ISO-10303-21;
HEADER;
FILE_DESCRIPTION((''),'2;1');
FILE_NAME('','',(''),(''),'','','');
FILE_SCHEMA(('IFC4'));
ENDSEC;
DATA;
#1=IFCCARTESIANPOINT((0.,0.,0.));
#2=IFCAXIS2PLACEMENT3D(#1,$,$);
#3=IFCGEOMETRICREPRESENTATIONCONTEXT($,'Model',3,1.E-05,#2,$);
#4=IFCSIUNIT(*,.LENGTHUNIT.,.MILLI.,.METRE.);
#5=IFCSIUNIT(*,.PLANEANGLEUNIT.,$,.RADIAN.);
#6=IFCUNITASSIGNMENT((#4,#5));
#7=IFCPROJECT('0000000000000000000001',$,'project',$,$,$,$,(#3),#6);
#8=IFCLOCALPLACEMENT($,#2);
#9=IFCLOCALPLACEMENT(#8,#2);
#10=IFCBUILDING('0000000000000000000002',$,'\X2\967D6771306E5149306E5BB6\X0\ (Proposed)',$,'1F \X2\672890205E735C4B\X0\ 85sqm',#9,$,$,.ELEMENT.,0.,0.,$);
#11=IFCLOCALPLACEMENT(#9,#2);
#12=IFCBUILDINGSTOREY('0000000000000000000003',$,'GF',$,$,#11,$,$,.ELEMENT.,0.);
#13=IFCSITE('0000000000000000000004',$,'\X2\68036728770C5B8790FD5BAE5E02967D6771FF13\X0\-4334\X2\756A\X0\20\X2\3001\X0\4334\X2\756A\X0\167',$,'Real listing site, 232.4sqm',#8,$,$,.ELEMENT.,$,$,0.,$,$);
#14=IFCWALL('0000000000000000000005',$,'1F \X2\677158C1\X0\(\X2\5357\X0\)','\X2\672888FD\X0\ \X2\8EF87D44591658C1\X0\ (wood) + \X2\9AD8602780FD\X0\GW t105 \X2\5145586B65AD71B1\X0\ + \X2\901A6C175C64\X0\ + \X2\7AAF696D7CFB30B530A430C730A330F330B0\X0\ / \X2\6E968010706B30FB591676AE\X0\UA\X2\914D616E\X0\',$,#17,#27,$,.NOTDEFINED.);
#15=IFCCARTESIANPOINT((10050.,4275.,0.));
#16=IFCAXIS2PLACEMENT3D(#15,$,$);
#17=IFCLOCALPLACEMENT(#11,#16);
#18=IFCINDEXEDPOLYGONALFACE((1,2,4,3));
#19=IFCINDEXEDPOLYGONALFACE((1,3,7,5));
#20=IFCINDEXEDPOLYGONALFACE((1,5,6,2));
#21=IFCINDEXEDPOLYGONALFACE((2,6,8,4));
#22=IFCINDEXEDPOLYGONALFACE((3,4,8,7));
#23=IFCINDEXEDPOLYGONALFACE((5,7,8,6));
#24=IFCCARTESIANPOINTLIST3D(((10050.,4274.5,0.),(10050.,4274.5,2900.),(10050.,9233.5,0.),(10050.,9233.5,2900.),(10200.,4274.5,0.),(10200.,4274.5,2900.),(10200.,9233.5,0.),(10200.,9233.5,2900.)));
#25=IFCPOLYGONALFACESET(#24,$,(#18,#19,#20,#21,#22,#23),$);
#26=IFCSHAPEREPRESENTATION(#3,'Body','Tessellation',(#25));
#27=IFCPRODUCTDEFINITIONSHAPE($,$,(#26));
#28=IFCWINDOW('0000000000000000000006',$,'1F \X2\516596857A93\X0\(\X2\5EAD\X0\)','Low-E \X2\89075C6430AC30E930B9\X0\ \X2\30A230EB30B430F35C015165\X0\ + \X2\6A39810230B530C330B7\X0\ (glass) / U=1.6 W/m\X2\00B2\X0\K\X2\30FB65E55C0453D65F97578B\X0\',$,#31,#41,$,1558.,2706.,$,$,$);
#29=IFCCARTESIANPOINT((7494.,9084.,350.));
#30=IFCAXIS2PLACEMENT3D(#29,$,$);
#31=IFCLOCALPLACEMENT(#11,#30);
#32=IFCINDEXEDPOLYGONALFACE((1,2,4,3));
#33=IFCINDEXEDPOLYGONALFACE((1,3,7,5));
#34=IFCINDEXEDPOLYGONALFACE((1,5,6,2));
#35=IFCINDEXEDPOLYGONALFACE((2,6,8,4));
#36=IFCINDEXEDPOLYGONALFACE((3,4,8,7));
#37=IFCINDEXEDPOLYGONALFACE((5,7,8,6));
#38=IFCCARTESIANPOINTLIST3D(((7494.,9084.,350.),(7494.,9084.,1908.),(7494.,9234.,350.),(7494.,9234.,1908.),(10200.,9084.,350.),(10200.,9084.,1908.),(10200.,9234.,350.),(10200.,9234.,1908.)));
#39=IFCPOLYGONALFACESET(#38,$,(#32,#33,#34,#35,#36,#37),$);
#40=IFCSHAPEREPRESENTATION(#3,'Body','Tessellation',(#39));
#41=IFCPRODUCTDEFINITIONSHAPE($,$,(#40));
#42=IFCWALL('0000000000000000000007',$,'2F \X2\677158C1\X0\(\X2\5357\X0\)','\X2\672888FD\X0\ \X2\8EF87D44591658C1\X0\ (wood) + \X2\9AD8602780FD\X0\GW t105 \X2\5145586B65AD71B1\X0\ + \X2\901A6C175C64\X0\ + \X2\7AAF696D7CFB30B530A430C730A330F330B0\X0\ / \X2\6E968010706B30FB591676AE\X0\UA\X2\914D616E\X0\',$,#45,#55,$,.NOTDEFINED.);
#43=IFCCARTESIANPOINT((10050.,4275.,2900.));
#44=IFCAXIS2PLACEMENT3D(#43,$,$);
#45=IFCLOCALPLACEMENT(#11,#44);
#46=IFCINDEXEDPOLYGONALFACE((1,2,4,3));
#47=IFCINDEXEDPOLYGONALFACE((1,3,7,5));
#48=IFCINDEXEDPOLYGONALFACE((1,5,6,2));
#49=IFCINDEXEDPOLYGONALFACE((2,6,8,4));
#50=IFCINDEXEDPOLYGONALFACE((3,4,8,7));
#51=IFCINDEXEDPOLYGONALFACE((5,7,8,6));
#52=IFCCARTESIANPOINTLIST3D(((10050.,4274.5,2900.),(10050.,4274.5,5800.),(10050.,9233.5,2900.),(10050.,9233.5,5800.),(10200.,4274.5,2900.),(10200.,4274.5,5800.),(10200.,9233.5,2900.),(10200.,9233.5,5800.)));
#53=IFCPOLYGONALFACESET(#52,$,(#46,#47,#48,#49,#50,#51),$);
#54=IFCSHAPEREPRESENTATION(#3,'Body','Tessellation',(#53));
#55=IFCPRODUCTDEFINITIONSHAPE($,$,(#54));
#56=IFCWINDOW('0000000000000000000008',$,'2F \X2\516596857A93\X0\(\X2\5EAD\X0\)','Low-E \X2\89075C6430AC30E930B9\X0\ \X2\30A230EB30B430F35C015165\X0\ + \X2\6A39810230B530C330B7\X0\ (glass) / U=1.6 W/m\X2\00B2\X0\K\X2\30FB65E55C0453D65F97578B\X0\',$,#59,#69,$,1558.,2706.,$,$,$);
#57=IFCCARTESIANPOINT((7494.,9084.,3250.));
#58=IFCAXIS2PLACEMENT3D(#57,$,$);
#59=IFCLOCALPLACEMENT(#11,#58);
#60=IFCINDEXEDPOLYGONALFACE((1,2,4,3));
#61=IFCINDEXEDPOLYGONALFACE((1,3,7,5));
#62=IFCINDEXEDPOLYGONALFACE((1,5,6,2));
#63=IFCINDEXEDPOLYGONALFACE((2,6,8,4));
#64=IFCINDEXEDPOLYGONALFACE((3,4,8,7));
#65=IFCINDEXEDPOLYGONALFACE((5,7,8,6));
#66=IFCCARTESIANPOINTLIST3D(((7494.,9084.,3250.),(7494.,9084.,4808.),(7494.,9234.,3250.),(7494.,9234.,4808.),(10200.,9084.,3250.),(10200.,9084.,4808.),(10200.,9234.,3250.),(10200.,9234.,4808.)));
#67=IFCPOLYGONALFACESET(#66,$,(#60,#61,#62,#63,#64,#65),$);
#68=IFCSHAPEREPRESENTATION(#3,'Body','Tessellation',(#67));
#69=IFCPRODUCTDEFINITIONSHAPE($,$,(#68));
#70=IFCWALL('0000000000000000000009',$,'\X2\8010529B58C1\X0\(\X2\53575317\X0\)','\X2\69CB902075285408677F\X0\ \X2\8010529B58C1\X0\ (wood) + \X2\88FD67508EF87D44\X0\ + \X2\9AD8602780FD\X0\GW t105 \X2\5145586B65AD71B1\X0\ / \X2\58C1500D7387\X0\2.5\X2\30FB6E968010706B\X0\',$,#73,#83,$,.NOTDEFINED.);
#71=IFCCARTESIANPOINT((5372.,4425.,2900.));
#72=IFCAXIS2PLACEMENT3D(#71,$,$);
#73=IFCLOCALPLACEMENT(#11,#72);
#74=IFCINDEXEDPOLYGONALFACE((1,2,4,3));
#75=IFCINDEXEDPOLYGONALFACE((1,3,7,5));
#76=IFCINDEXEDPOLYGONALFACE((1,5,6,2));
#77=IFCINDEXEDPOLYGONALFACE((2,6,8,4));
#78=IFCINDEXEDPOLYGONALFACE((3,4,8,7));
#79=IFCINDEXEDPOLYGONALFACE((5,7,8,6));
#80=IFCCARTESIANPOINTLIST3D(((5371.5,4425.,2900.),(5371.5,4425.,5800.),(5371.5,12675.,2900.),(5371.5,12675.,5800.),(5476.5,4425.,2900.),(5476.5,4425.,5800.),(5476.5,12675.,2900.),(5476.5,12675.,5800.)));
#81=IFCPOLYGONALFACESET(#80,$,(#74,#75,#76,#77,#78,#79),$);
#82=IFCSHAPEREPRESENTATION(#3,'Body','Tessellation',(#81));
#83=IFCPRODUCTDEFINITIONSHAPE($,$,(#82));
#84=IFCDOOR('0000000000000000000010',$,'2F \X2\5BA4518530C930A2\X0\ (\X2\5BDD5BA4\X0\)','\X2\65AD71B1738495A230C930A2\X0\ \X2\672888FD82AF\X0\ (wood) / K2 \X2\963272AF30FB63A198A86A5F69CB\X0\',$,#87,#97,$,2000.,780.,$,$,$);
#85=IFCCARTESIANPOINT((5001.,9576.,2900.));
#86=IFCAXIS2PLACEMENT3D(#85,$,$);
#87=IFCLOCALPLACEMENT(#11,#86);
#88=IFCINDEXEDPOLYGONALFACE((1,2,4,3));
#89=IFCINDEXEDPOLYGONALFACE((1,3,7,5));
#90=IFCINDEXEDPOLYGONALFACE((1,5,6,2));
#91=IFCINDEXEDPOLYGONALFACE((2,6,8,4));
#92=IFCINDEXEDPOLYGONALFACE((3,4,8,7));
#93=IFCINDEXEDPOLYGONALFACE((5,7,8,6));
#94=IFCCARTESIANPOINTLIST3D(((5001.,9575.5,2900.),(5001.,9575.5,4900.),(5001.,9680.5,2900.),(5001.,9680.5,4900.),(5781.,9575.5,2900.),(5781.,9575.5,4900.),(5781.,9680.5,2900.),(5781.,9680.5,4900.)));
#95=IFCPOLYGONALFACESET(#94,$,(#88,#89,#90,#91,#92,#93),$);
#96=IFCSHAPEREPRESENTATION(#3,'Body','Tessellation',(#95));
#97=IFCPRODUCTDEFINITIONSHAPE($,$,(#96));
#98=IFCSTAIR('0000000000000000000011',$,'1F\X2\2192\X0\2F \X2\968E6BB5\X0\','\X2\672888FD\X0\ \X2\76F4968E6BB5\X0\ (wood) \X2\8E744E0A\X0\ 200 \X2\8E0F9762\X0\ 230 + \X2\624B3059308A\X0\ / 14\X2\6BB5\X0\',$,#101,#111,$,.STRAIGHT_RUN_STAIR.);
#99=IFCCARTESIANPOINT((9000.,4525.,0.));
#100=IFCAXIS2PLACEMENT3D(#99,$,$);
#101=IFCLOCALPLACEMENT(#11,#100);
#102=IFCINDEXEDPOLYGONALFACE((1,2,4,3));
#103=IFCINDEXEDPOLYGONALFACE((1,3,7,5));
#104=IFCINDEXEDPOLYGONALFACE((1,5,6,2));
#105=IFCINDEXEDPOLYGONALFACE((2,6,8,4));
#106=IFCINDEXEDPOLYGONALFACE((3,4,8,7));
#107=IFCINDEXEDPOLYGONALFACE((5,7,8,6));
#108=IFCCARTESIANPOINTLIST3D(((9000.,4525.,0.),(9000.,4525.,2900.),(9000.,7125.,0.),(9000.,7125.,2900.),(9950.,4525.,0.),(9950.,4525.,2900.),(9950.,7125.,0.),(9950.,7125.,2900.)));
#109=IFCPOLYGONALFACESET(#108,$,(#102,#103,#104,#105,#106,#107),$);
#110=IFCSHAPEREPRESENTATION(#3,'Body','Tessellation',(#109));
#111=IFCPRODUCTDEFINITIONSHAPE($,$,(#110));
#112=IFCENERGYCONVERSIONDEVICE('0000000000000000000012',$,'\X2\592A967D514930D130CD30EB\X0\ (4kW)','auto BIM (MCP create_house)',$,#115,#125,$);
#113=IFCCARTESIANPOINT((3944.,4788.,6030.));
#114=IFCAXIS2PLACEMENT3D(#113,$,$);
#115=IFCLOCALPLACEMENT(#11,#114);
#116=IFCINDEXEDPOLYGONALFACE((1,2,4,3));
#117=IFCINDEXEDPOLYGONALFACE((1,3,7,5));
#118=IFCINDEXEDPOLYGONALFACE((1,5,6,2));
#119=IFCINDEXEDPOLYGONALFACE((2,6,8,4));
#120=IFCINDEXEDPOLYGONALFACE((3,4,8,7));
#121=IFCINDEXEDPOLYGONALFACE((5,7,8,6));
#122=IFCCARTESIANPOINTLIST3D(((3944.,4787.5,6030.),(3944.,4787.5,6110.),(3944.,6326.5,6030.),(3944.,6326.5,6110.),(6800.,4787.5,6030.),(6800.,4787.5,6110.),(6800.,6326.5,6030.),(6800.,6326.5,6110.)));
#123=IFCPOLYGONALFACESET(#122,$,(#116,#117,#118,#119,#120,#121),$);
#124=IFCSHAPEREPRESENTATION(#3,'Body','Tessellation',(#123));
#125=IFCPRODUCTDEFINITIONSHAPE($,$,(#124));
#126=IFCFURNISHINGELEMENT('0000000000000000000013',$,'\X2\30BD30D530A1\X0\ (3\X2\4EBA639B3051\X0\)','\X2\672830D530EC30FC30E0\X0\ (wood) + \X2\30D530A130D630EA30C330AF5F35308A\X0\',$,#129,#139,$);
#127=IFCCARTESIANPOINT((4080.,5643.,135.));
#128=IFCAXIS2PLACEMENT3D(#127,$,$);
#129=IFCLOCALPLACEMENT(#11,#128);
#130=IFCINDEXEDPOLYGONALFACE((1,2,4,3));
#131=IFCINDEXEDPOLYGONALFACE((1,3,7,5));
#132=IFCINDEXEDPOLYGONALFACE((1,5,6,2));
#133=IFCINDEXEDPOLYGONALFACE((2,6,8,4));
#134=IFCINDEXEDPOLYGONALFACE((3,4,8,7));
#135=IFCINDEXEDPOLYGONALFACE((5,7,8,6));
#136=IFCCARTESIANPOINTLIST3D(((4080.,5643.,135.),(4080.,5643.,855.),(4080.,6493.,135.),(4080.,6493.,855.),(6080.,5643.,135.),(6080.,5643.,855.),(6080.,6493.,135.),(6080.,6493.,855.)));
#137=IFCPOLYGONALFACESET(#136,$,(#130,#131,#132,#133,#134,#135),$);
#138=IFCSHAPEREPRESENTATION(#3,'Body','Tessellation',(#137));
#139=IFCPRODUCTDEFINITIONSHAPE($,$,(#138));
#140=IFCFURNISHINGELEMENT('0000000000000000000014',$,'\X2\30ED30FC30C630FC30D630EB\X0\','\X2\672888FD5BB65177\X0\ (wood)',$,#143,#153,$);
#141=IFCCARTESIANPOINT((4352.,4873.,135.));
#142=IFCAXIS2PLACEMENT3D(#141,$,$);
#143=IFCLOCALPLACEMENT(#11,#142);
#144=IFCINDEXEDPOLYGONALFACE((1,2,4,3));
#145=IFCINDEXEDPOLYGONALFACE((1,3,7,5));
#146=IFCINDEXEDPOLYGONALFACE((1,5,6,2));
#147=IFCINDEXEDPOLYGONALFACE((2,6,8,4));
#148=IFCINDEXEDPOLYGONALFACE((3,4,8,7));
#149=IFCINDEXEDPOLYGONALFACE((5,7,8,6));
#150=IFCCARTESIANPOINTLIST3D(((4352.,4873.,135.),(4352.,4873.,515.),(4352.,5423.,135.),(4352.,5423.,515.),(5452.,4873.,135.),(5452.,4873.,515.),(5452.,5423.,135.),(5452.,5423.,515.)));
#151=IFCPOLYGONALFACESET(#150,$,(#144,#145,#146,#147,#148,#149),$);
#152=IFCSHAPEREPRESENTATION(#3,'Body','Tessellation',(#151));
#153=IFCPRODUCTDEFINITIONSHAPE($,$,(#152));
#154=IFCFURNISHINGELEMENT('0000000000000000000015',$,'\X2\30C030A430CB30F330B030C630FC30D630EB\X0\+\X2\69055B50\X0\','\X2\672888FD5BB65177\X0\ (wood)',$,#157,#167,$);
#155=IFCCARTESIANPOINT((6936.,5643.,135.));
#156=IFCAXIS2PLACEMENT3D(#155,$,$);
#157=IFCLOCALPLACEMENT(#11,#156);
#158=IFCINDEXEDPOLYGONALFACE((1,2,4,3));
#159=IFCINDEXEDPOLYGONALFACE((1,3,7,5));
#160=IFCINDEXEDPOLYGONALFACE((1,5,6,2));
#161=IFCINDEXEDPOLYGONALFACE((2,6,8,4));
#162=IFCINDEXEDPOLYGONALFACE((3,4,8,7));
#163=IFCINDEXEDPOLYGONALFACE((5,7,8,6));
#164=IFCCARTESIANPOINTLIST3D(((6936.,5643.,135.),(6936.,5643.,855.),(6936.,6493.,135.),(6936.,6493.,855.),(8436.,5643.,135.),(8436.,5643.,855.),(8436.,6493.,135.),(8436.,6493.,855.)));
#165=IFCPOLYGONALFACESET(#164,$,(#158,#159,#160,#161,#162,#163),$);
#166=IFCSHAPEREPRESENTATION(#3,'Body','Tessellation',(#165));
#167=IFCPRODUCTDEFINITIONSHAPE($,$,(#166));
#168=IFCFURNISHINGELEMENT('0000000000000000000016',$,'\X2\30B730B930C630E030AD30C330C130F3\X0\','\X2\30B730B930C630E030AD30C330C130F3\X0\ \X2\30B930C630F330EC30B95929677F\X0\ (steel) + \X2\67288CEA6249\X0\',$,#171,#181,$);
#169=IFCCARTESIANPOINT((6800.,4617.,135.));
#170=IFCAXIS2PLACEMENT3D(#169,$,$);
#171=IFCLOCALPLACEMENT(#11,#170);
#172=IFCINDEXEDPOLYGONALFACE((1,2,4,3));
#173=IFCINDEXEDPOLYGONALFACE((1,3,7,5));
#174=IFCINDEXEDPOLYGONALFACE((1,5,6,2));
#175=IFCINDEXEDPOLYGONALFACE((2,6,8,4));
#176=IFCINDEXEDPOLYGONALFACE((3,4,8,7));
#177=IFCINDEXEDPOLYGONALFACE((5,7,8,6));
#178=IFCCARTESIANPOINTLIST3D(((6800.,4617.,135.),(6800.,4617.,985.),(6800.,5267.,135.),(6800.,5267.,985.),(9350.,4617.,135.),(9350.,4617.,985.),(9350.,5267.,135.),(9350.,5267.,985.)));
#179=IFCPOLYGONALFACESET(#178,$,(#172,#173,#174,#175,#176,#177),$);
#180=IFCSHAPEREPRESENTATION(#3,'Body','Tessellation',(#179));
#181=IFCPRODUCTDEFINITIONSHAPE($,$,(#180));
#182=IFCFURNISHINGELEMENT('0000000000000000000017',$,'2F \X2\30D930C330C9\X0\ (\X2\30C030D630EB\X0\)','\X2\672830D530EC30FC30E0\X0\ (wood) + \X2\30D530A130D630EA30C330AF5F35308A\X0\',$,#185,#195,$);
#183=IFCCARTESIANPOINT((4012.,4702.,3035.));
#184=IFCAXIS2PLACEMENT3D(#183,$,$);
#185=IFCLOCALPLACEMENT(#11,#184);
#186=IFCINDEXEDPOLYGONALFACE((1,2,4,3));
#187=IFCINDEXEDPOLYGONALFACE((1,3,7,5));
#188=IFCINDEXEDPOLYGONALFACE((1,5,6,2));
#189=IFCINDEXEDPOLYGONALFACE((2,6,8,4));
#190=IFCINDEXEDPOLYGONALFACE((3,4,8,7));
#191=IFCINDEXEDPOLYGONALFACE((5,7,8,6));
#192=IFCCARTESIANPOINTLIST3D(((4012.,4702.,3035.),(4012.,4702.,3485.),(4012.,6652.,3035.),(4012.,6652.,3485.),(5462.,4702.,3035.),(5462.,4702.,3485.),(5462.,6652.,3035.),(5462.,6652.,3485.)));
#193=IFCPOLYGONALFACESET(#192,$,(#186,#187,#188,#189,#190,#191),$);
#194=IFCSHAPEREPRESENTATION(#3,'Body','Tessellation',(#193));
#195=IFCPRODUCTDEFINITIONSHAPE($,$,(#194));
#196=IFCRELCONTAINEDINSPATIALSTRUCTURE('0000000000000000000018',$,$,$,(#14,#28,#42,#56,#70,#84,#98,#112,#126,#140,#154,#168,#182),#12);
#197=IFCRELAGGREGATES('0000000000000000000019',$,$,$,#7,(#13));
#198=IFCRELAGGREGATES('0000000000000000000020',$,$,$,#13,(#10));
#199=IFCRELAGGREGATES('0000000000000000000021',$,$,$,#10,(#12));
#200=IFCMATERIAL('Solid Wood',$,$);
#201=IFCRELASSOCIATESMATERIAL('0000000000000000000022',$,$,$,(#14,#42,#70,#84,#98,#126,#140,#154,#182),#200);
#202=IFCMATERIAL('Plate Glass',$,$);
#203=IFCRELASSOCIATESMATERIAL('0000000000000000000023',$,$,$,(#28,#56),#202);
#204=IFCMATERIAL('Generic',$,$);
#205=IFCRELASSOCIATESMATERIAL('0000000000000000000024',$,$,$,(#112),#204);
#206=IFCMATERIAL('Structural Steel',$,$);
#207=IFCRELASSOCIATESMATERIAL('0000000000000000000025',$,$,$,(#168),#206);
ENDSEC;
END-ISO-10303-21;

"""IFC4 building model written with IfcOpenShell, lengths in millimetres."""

from ifc_helpers import new_model, si_unit, frame, frame_2d, origin, place, context, project, spatial, rectangle, extrude, material, element, fill, save


model = new_model("IFC4")

# Units and contexts
model_context = context("Model", 3, precision=1e-05, world=origin())
ifc_project = project(units=[si_unit("LENGTHUNIT", "METRE", prefix="MILLI"), si_unit("PLANEANGLEUNIT", "RADIAN")], contexts=[model_context])

# Site, building, storey
site_placement = place(None, origin())
site = spatial("IfcSite", under=ifc_project, at=site_placement, Name="栃木県宇都宮市陽東３-4334番20、4334番167", ObjectType="Real listing site, 232.4sqm", CompositionType="ELEMENT", RefElevation=0.0)
building_placement = place(site_placement, origin())
building = spatial("IfcBuilding", under=site, at=building_placement, Name="陽東の光の家 (Proposed)", ObjectType="1F 木造平屋 85sqm", CompositionType="ELEMENT", ElevationOfRefHeight=0.0, ElevationOfTerrain=0.0)
storey_placement = place(building_placement, origin())
storey = spatial("IfcBuildingStorey", under=building, at=storey_placement, Name="GF", CompositionType="ELEMENT", Elevation=0.0)

# Wall, opening, window
ifc_material_1 = material(Name="Solid Wood")
wall_1_placement = place(storey_placement, frame((10050.0, 4275.0, 0.0)))
wall_1 = element("IfcWall", 1, at=wall_1_placement, inside=storey, material=ifc_material_1, Name="1F 東壁(南)", Description="木製 軸組外壁 (wood) + 高性能GW t105 充填断熱 + 通気層 + 窯業系サイディング / 準耐火・外皮UA配慮", PredefinedType="NOTDEFINED", context=model_context, shape_type="SweptSolid", body=[
    extrude(rectangle(XDim=150.0, YDim=4959.0, at=frame_2d((75.0, 2479.0))), frame((10050.0, 4275.0, 0.0)), (0.0, 0.0, 1.0), 2900.0),
])
opening_1_placement = place(storey_placement, frame((7494.0, 9084.0, 350.0)))
opening_1 = element("IfcOpeningElement", 2, at=opening_1_placement, cuts=wall_1, PredefinedType="NOTDEFINED", context=model_context, shape_type="SweptSolid", body=[
    extrude(rectangle(XDim=2706.0, YDim=150.0, at=frame_2d((1353.0, 75.0))), frame((7494.0, 9084.0, 350.0)), (0.0, 0.0, 1.0), 1558.0),
])
ifc_material_2 = material(Name="Plate Glass")
window_1_placement = place(storey_placement, frame((7494.0, 9084.0, 350.0)))
window_1 = element("IfcWindow", 3, at=window_1_placement, inside=storey, material=ifc_material_2, Name="1F 入隅窓(庭)", Description="Low-E 複層ガラス アルゴン封入 + 樹脂サッシ (glass) / U=1.6 W/m²K・日射取得型", OverallHeight=1558.0, OverallWidth=2706.0, context=model_context, shape_type="SweptSolid", body=[
    extrude(rectangle(XDim=2706.0, YDim=150.0, at=frame_2d((1353.0, 75.0))), frame((7494.0, 9084.0, 350.0)), (0.0, 0.0, 1.0), 1558.0),
])
fill(opening_1, window_1)

# Wall, opening, window
wall_2_placement = place(storey_placement, frame((10050.0, 4275.0, 2900.0)))
wall_2 = element("IfcWall", 4, at=wall_2_placement, inside=storey, material=ifc_material_1, Name="2F 東壁(南)", Description="木製 軸組外壁 (wood) + 高性能GW t105 充填断熱 + 通気層 + 窯業系サイディング / 準耐火・外皮UA配慮", PredefinedType="NOTDEFINED", context=model_context, shape_type="SweptSolid", body=[
    extrude(rectangle(XDim=150.0, YDim=4959.0, at=frame_2d((75.0, 2479.0))), frame((10050.0, 4275.0, 2900.0)), (0.0, 0.0, 1.0), 2900.0),
])
opening_2_placement = place(storey_placement, frame((7494.0, 9084.0, 3250.0)))
opening_2 = element("IfcOpeningElement", 5, at=opening_2_placement, cuts=wall_2, PredefinedType="NOTDEFINED", context=model_context, shape_type="SweptSolid", body=[
    extrude(rectangle(XDim=2706.0, YDim=150.0, at=frame_2d((1353.0, 75.0))), frame((7494.0, 9084.0, 3250.0)), (0.0, 0.0, 1.0), 1558.0),
])
window_2_placement = place(storey_placement, frame((7494.0, 9084.0, 3250.0)))
window_2 = element("IfcWindow", 6, at=window_2_placement, inside=storey, material=ifc_material_2, Name="2F 入隅窓(庭)", Description="Low-E 複層ガラス アルゴン封入 + 樹脂サッシ (glass) / U=1.6 W/m²K・日射取得型", OverallHeight=1558.0, OverallWidth=2706.0, context=model_context, shape_type="SweptSolid", body=[
    extrude(rectangle(XDim=2706.0, YDim=150.0, at=frame_2d((1353.0, 75.0))), frame((7494.0, 9084.0, 3250.0)), (0.0, 0.0, 1.0), 1558.0),
])
fill(opening_2, window_2)

# Wall, opening, door
wall_3_placement = place(storey_placement, frame((5372.0, 4425.0, 2900.0)))
wall_3 = element("IfcWall", 7, at=wall_3_placement, inside=storey, material=ifc_material_1, Name="耐力壁(南北)", Description="構造用合板 耐力壁 (wood) + 製材軸組 + 高性能GW t105 充填断熱 / 壁倍率2.5・準耐火", PredefinedType="NOTDEFINED", context=model_context, shape_type="SweptSolid", body=[
    extrude(rectangle(XDim=105.0, YDim=8250.0, at=frame_2d((52.0, 4125.0))), frame((5372.0, 4425.0, 2900.0)), (0.0, 0.0, 1.0), 2900.0),
])
opening_3_placement = place(storey_placement, frame((5001.0, 9576.0, 2900.0)))
opening_3 = element("IfcOpeningElement", 8, at=opening_3_placement, cuts=wall_3, PredefinedType="NOTDEFINED", context=model_context, shape_type="SweptSolid", body=[
    extrude(rectangle(XDim=780.0, YDim=105.0, at=frame_2d((390.0, 52.0))), frame((5001.0, 9576.0, 2900.0)), (0.0, 0.0, 1.0), 2000.0),
])
door_1_placement = place(storey_placement, frame((5001.0, 9576.0, 2900.0)))
door_1 = element("IfcDoor", 9, at=door_1_placement, inside=storey, material=ifc_material_1, Name="2F 室内ドア (寝室)", Description="断熱玄関ドア 木製芯 (wood) / K2 防犯・採風機構", OverallHeight=2000.0, OverallWidth=780.0, context=model_context, shape_type="SweptSolid", body=[
    extrude(rectangle(XDim=780.0, YDim=105.0, at=frame_2d((390.0, 52.0))), frame((5001.0, 9576.0, 2900.0)), (0.0, 0.0, 1.0), 2000.0),
])
fill(opening_3, door_1)

# Stair
stair_placement = place(storey_placement, frame((9000.0, 4525.0, 0.0)))
element("IfcStair", 10, at=stair_placement, inside=storey, material=ifc_material_1, Name="1F→2F 階段", Description="木製 直階段 (wood) 蹴上 200 踏面 230 + 手すり / 14段", PredefinedType="STRAIGHT_RUN_STAIR", context=model_context, shape_type="SweptSolid", body=[
    extrude(rectangle(XDim=950.0, YDim=2600.0, at=frame_2d((475.0, 1300.0))), frame((9000.0, 4525.0, 0.0)), (0.0, 0.0, 1.0), 2900.0),
])

# Energy conversion device
ifc_material_3 = material(Name="Generic")
energy_conversion_device_placement = place(storey_placement, frame((3944.0, 4788.0, 6030.0)))
element("IfcEnergyConversionDevice", 11, at=energy_conversion_device_placement, inside=storey, material=ifc_material_3, Name="太陽光パネル (4kW)", Description="auto BIM (MCP create_house)", context=model_context, shape_type="SweptSolid", body=[
    extrude(rectangle(XDim=2856.0, YDim=1539.0, at=frame_2d((1428.0, 769.0))), frame((3944.0, 4788.0, 6030.0)), (0.0, 0.0, 1.0), 80.0),
])

# Furnishing elements
furnishing_1_placement = place(storey_placement, frame((4080.0, 5643.0, 135.0)))
element("IfcFurnishingElement", 12, at=furnishing_1_placement, inside=storey, material=ifc_material_1, Name="ソファ (3人掛け)", Description="木フレーム (wood) + ファブリック張り", context=model_context, shape_type="SweptSolid", body=[
    extrude(rectangle(XDim=2000.0, YDim=850.0, at=frame_2d((1000.0, 425.0))), frame((4080.0, 5643.0, 135.0)), (0.0, 0.0, 1.0), 720.0),
])
furnishing_2_placement = place(storey_placement, frame((4352.0, 4873.0, 135.0)))
element("IfcFurnishingElement", 13, at=furnishing_2_placement, inside=storey, material=ifc_material_1, Name="ローテーブル", Description="木製家具 (wood)", context=model_context, shape_type="SweptSolid", body=[
    extrude(rectangle(XDim=1100.0, YDim=550.0, at=frame_2d((550.0, 275.0))), frame((4352.0, 4873.0, 135.0)), (0.0, 0.0, 1.0), 380.0),
])
furnishing_3_placement = place(storey_placement, frame((6936.0, 5643.0, 135.0)))
element("IfcFurnishingElement", 14, at=furnishing_3_placement, inside=storey, material=ifc_material_1, Name="ダイニングテーブル+椅子", Description="木製家具 (wood)", context=model_context, shape_type="SweptSolid", body=[
    extrude(rectangle(XDim=1500.0, YDim=850.0, at=frame_2d((750.0, 425.0))), frame((6936.0, 5643.0, 135.0)), (0.0, 0.0, 1.0), 720.0),
])
ifc_material_4 = material(Name="Structural Steel")
furnishing_4_placement = place(storey_placement, frame((6800.0, 4617.0, 135.0)))
element("IfcFurnishingElement", 15, at=furnishing_4_placement, inside=storey, material=ifc_material_4, Name="システムキッチン", Description="システムキッチン ステンレス天板 (steel) + 木質扉", context=model_context, shape_type="SweptSolid", body=[
    extrude(rectangle(XDim=2550.0, YDim=650.0, at=frame_2d((1275.0, 325.0))), frame((6800.0, 4617.0, 135.0)), (0.0, 0.0, 1.0), 850.0),
])
furnishing_5_placement = place(storey_placement, frame((4012.0, 4702.0, 3035.0)))
element("IfcFurnishingElement", 16, at=furnishing_5_placement, inside=storey, material=ifc_material_1, Name="2F ベッド (ダブル)", Description="木フレーム (wood) + ファブリック張り", context=model_context, shape_type="SweptSolid", body=[
    extrude(rectangle(XDim=1450.0, YDim=1950.0, at=frame_2d((725.0, 975.0))), frame((4012.0, 4702.0, 3035.0)), (0.0, 0.0, 1.0), 450.0),
])

save(model, "model.ifc")
